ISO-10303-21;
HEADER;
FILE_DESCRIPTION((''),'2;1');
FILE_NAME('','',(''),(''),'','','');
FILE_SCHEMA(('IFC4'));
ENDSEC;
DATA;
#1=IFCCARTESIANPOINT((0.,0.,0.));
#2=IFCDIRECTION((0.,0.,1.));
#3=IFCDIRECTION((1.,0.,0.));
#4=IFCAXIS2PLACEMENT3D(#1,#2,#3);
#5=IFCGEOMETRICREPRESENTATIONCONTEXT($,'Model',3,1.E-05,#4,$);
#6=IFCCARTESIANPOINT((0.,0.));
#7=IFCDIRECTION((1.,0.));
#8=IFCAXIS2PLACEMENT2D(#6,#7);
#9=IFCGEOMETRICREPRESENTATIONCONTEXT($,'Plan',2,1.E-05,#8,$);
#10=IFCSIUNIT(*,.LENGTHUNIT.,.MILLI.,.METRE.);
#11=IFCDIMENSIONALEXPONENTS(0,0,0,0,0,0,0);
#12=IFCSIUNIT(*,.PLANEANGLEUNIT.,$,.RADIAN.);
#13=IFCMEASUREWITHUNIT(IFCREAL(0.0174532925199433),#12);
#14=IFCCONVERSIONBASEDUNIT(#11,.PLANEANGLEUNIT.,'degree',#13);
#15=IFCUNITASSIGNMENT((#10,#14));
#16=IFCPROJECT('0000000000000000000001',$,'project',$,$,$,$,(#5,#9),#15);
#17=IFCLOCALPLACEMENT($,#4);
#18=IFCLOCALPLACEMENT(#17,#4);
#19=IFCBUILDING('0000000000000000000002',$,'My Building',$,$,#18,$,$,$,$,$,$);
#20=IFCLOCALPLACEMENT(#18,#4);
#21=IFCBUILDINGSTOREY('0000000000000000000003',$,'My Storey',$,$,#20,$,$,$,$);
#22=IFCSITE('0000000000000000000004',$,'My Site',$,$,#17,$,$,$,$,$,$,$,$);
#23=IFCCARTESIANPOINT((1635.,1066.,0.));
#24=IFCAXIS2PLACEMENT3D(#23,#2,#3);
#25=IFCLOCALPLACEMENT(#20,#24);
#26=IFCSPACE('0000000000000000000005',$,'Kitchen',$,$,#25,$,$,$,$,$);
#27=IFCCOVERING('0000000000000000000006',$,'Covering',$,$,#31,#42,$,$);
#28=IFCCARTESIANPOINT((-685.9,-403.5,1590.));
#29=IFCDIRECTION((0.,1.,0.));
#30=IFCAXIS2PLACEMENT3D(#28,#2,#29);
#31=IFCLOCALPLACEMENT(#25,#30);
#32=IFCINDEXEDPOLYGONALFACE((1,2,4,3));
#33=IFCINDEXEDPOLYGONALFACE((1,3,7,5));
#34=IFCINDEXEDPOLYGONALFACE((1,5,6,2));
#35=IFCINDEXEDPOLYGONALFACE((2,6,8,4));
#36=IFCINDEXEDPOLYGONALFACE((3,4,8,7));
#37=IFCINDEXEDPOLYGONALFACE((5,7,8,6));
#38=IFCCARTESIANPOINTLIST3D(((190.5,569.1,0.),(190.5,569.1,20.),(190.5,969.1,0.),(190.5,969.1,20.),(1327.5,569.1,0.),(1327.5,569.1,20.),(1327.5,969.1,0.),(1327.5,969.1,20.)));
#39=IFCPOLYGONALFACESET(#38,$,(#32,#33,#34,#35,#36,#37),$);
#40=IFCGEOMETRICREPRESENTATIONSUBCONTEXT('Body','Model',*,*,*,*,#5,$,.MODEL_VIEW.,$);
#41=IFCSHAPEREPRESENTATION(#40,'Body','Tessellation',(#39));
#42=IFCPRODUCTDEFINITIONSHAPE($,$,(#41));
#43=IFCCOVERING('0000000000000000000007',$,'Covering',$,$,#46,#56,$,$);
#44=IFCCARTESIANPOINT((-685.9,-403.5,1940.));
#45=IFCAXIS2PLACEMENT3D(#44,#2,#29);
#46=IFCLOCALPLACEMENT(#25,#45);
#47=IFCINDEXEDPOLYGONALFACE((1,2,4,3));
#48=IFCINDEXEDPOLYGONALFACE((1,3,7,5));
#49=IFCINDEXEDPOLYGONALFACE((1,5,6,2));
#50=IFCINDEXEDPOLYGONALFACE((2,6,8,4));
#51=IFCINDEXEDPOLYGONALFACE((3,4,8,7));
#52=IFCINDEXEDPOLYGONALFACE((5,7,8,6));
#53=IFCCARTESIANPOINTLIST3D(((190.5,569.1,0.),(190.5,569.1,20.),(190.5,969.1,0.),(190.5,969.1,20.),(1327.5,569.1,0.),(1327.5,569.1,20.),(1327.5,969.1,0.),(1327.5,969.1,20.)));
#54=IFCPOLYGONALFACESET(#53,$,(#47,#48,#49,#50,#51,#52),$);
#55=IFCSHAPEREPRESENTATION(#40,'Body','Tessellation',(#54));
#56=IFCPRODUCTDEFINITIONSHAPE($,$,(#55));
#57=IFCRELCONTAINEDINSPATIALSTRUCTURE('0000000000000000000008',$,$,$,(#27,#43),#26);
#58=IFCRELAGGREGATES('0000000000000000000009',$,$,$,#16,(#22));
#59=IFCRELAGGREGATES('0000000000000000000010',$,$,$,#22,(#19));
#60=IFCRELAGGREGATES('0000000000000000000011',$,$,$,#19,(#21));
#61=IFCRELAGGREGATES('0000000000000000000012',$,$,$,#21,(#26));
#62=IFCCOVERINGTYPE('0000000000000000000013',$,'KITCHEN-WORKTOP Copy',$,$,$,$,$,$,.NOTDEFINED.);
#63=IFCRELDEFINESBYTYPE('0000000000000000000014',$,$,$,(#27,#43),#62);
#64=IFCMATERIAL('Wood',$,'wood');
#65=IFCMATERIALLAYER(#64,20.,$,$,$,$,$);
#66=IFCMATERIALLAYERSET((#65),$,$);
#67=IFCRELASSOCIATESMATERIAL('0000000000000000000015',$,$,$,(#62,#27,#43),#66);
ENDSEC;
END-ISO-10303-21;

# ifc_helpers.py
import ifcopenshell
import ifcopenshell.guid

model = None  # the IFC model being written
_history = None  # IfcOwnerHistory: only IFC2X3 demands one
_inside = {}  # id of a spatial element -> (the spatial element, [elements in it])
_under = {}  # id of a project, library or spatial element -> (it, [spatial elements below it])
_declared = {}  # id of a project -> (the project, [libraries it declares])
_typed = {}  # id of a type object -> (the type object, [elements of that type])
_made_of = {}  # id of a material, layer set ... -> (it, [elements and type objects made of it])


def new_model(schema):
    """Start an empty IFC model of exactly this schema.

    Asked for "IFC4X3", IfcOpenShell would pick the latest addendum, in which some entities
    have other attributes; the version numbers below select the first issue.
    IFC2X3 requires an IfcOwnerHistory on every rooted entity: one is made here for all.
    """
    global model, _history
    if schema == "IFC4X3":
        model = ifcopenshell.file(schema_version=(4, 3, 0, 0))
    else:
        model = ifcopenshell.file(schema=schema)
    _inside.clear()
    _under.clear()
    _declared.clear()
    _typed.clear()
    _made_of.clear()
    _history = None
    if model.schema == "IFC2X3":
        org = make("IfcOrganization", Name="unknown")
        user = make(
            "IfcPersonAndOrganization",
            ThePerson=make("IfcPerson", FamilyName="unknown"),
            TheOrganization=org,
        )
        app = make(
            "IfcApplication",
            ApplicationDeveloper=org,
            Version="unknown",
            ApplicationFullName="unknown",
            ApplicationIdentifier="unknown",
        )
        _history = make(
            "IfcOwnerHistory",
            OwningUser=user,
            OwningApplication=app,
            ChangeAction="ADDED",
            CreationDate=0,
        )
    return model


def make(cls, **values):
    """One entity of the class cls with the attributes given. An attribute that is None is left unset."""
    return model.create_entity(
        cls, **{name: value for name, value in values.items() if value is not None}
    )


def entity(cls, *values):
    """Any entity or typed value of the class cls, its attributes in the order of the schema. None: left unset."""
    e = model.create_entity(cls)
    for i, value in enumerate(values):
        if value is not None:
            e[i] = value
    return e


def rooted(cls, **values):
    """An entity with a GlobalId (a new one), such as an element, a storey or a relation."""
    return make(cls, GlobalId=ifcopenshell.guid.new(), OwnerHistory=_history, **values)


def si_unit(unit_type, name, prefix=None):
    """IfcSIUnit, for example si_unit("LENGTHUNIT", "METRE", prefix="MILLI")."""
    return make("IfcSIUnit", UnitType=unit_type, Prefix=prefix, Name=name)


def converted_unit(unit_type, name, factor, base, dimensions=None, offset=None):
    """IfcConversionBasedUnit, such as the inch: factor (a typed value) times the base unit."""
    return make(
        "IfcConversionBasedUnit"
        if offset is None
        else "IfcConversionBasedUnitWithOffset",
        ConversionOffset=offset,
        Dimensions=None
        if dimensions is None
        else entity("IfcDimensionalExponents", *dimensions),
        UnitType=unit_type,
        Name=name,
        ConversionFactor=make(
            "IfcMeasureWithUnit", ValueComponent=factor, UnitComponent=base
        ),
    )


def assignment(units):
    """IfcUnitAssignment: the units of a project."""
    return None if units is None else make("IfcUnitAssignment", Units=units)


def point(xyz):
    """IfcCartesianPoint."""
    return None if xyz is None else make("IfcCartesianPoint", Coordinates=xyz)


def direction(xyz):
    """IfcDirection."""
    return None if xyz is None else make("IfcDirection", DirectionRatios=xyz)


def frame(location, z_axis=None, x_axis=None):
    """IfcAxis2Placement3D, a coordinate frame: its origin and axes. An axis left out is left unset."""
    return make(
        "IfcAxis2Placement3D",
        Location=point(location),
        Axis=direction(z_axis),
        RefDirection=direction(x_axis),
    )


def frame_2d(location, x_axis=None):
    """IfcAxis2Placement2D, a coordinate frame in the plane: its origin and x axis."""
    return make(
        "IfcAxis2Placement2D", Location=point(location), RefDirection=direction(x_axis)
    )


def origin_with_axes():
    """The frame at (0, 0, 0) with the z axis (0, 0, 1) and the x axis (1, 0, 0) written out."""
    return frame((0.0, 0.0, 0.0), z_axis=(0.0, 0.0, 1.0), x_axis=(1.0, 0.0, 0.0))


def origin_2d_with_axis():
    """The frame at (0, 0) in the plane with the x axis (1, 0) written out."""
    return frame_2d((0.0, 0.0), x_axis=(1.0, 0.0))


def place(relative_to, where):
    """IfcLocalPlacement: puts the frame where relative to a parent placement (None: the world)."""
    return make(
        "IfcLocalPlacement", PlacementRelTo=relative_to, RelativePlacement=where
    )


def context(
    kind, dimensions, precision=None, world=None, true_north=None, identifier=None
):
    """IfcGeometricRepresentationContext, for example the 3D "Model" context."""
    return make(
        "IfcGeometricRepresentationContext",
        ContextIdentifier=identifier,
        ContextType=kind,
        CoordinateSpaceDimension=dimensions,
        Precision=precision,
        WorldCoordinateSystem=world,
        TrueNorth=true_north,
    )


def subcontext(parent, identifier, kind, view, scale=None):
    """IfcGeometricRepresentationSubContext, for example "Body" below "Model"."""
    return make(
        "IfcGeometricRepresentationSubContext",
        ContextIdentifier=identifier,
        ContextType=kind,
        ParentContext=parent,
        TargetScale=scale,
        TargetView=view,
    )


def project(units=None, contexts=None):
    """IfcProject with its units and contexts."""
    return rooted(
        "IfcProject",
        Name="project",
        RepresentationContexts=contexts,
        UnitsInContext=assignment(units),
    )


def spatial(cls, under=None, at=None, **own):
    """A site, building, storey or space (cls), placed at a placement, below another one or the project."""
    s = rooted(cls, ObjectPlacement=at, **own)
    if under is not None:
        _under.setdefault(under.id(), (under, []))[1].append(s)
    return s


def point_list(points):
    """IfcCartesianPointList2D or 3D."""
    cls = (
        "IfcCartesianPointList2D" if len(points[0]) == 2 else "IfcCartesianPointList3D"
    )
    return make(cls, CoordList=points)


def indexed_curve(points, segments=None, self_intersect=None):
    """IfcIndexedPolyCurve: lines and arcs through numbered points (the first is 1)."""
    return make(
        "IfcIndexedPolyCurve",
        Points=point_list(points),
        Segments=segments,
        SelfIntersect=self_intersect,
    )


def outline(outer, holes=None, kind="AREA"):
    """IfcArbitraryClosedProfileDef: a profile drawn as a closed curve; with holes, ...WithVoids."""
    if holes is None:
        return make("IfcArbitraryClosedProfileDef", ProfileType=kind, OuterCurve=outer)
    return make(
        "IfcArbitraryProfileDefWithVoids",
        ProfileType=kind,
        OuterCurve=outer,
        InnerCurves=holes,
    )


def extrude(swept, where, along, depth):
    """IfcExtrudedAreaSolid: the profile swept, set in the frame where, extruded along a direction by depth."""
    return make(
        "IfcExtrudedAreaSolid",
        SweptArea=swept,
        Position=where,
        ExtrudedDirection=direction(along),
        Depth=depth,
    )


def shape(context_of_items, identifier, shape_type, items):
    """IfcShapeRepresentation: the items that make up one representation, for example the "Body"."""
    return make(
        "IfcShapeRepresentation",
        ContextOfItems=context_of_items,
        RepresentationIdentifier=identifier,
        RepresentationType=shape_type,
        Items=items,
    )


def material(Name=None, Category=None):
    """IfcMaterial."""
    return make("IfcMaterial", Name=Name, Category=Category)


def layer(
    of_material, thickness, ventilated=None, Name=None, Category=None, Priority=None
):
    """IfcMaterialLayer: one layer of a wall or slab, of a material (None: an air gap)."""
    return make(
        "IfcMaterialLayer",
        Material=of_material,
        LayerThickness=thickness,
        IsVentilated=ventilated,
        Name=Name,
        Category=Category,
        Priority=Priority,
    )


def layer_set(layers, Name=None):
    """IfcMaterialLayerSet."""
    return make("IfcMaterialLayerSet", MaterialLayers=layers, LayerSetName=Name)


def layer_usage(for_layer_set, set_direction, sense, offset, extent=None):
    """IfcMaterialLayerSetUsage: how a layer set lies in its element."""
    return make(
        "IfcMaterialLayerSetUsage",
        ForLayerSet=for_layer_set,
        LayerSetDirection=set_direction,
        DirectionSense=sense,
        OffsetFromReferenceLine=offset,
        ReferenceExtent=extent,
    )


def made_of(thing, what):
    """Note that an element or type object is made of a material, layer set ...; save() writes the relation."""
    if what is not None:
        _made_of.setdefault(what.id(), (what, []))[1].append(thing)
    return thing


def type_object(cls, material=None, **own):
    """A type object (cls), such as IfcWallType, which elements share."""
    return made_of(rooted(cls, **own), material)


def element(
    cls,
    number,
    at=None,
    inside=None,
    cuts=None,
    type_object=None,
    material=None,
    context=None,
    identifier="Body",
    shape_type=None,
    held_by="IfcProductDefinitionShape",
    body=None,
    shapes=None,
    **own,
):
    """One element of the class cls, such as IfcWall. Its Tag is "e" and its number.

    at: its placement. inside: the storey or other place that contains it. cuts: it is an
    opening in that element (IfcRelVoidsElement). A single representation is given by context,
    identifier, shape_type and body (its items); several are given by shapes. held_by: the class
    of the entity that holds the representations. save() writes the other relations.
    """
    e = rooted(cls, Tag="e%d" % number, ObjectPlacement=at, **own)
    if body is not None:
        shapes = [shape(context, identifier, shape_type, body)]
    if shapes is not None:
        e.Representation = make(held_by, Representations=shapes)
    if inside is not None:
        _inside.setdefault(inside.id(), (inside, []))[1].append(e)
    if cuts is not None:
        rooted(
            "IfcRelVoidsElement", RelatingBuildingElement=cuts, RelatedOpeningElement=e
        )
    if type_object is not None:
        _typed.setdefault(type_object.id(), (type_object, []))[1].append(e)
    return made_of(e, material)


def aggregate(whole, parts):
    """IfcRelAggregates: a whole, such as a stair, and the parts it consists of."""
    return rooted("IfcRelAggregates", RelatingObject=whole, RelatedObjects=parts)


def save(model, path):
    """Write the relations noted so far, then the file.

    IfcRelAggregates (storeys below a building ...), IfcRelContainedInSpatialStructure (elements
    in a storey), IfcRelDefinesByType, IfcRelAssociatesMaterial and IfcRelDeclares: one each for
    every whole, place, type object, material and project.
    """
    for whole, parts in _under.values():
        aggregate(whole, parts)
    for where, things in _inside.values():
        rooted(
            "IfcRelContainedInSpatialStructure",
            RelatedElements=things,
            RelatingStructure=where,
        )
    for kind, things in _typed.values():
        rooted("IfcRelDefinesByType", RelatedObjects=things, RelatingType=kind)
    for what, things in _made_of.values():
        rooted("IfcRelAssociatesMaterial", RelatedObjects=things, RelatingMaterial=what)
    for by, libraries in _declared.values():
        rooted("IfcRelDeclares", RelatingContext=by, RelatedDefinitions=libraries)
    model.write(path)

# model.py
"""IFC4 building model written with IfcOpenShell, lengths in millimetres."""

from ifc_helpers import new_model, entity, si_unit, converted_unit, frame, origin_with_axes, origin_2d_with_axis, place, context, subcontext, project, spatial, indexed_curve, outline, extrude, material, layer, layer_set, layer_usage, type_object, element, save


model = new_model("IFC4")

# Units and contexts
model_context = context("Model", 3, precision=1e-05, world=origin_with_axes())
plan_context = context("Plan", 2, precision=1e-05, world=origin_2d_with_axis())
body_context = subcontext(model_context, "Body", "Model", "MODEL_VIEW")
ifc_project = project(units=[si_unit("LENGTHUNIT", "METRE", prefix="MILLI"), converted_unit("PLANEANGLEUNIT", "degree", entity("IfcReal", 0.0174532925199433), si_unit("PLANEANGLEUNIT", "RADIAN"), dimensions=[0, 0, 0, 0, 0, 0, 0])], contexts=[model_context, plan_context])

# Site, building, storey, space
site_placement = place(None, origin_with_axes())
site = spatial("IfcSite", under=ifc_project, at=site_placement, Name="My Site")
building_placement = place(site_placement, origin_with_axes())
building = spatial("IfcBuilding", under=site, at=building_placement, Name="My Building")
storey_placement = place(building_placement, origin_with_axes())
storey = spatial("IfcBuildingStorey", under=building, at=storey_placement, Name="My Storey")
space_placement = place(storey_placement, frame((1635.0, 1066.0, 0.0), z_axis=(0.0, 0.0, 1.0), x_axis=(1.0, 0.0, 0.0)))
space = spatial("IfcSpace", under=storey, at=space_placement, Name="Kitchen")

# Shared definitions
ifc_material_1 = material(Name="Wood", Category="wood")

# Coverings
ifc_layer_1 = layer(ifc_material_1, 20.0)
ifc_layer_set_1 = layer_set([ifc_layer_1])
covering_type_1 = type_object("IfcCoveringType", Name="KITCHEN-WORKTOP Copy", PredefinedType="NOTDEFINED", material=ifc_layer_set_1)
ifc_layer_usage_1 = layer_usage(ifc_layer_set_1, "AXIS3", "POSITIVE", 0.0)
covering_1_placement = place(space_placement, frame((-685.9, -403.5, 1590.0), z_axis=(0.0, 0.0, 1.0), x_axis=(0.0, 1.0, 0.0)))
element("IfcCovering", 1, at=covering_1_placement, inside=space, type_object=covering_type_1, material=ifc_layer_usage_1, Name="Covering", context=body_context, shape_type="SweptSolid", body=[
    extrude(outline(indexed_curve([(1327.5, 569.1), (1327.5, 969.1), (190.5, 969.1), (190.5, 569.1), (1327.5, 569.1)])), None, (0.0, 0.0, 1.0), 20.0),
])
ifc_layer_usage_2 = layer_usage(ifc_layer_set_1, "AXIS3", "POSITIVE", 0.0)
covering_2_placement = place(space_placement, frame((-685.9, -403.5, 1940.0), z_axis=(0.0, 0.0, 1.0), x_axis=(0.0, 1.0, 0.0)))
element("IfcCovering", 2, at=covering_2_placement, inside=space, type_object=covering_type_1, material=ifc_layer_usage_2, Name="Covering", context=body_context, shape_type="SweptSolid", body=[
    extrude(outline(indexed_curve([(1327.5, 569.1), (1327.5, 969.1), (190.5, 969.1), (190.5, 569.1), (1327.5, 569.1)])), None, (0.0, 0.0, 1.0), 20.0),
])

save(model, "model.ifc")
